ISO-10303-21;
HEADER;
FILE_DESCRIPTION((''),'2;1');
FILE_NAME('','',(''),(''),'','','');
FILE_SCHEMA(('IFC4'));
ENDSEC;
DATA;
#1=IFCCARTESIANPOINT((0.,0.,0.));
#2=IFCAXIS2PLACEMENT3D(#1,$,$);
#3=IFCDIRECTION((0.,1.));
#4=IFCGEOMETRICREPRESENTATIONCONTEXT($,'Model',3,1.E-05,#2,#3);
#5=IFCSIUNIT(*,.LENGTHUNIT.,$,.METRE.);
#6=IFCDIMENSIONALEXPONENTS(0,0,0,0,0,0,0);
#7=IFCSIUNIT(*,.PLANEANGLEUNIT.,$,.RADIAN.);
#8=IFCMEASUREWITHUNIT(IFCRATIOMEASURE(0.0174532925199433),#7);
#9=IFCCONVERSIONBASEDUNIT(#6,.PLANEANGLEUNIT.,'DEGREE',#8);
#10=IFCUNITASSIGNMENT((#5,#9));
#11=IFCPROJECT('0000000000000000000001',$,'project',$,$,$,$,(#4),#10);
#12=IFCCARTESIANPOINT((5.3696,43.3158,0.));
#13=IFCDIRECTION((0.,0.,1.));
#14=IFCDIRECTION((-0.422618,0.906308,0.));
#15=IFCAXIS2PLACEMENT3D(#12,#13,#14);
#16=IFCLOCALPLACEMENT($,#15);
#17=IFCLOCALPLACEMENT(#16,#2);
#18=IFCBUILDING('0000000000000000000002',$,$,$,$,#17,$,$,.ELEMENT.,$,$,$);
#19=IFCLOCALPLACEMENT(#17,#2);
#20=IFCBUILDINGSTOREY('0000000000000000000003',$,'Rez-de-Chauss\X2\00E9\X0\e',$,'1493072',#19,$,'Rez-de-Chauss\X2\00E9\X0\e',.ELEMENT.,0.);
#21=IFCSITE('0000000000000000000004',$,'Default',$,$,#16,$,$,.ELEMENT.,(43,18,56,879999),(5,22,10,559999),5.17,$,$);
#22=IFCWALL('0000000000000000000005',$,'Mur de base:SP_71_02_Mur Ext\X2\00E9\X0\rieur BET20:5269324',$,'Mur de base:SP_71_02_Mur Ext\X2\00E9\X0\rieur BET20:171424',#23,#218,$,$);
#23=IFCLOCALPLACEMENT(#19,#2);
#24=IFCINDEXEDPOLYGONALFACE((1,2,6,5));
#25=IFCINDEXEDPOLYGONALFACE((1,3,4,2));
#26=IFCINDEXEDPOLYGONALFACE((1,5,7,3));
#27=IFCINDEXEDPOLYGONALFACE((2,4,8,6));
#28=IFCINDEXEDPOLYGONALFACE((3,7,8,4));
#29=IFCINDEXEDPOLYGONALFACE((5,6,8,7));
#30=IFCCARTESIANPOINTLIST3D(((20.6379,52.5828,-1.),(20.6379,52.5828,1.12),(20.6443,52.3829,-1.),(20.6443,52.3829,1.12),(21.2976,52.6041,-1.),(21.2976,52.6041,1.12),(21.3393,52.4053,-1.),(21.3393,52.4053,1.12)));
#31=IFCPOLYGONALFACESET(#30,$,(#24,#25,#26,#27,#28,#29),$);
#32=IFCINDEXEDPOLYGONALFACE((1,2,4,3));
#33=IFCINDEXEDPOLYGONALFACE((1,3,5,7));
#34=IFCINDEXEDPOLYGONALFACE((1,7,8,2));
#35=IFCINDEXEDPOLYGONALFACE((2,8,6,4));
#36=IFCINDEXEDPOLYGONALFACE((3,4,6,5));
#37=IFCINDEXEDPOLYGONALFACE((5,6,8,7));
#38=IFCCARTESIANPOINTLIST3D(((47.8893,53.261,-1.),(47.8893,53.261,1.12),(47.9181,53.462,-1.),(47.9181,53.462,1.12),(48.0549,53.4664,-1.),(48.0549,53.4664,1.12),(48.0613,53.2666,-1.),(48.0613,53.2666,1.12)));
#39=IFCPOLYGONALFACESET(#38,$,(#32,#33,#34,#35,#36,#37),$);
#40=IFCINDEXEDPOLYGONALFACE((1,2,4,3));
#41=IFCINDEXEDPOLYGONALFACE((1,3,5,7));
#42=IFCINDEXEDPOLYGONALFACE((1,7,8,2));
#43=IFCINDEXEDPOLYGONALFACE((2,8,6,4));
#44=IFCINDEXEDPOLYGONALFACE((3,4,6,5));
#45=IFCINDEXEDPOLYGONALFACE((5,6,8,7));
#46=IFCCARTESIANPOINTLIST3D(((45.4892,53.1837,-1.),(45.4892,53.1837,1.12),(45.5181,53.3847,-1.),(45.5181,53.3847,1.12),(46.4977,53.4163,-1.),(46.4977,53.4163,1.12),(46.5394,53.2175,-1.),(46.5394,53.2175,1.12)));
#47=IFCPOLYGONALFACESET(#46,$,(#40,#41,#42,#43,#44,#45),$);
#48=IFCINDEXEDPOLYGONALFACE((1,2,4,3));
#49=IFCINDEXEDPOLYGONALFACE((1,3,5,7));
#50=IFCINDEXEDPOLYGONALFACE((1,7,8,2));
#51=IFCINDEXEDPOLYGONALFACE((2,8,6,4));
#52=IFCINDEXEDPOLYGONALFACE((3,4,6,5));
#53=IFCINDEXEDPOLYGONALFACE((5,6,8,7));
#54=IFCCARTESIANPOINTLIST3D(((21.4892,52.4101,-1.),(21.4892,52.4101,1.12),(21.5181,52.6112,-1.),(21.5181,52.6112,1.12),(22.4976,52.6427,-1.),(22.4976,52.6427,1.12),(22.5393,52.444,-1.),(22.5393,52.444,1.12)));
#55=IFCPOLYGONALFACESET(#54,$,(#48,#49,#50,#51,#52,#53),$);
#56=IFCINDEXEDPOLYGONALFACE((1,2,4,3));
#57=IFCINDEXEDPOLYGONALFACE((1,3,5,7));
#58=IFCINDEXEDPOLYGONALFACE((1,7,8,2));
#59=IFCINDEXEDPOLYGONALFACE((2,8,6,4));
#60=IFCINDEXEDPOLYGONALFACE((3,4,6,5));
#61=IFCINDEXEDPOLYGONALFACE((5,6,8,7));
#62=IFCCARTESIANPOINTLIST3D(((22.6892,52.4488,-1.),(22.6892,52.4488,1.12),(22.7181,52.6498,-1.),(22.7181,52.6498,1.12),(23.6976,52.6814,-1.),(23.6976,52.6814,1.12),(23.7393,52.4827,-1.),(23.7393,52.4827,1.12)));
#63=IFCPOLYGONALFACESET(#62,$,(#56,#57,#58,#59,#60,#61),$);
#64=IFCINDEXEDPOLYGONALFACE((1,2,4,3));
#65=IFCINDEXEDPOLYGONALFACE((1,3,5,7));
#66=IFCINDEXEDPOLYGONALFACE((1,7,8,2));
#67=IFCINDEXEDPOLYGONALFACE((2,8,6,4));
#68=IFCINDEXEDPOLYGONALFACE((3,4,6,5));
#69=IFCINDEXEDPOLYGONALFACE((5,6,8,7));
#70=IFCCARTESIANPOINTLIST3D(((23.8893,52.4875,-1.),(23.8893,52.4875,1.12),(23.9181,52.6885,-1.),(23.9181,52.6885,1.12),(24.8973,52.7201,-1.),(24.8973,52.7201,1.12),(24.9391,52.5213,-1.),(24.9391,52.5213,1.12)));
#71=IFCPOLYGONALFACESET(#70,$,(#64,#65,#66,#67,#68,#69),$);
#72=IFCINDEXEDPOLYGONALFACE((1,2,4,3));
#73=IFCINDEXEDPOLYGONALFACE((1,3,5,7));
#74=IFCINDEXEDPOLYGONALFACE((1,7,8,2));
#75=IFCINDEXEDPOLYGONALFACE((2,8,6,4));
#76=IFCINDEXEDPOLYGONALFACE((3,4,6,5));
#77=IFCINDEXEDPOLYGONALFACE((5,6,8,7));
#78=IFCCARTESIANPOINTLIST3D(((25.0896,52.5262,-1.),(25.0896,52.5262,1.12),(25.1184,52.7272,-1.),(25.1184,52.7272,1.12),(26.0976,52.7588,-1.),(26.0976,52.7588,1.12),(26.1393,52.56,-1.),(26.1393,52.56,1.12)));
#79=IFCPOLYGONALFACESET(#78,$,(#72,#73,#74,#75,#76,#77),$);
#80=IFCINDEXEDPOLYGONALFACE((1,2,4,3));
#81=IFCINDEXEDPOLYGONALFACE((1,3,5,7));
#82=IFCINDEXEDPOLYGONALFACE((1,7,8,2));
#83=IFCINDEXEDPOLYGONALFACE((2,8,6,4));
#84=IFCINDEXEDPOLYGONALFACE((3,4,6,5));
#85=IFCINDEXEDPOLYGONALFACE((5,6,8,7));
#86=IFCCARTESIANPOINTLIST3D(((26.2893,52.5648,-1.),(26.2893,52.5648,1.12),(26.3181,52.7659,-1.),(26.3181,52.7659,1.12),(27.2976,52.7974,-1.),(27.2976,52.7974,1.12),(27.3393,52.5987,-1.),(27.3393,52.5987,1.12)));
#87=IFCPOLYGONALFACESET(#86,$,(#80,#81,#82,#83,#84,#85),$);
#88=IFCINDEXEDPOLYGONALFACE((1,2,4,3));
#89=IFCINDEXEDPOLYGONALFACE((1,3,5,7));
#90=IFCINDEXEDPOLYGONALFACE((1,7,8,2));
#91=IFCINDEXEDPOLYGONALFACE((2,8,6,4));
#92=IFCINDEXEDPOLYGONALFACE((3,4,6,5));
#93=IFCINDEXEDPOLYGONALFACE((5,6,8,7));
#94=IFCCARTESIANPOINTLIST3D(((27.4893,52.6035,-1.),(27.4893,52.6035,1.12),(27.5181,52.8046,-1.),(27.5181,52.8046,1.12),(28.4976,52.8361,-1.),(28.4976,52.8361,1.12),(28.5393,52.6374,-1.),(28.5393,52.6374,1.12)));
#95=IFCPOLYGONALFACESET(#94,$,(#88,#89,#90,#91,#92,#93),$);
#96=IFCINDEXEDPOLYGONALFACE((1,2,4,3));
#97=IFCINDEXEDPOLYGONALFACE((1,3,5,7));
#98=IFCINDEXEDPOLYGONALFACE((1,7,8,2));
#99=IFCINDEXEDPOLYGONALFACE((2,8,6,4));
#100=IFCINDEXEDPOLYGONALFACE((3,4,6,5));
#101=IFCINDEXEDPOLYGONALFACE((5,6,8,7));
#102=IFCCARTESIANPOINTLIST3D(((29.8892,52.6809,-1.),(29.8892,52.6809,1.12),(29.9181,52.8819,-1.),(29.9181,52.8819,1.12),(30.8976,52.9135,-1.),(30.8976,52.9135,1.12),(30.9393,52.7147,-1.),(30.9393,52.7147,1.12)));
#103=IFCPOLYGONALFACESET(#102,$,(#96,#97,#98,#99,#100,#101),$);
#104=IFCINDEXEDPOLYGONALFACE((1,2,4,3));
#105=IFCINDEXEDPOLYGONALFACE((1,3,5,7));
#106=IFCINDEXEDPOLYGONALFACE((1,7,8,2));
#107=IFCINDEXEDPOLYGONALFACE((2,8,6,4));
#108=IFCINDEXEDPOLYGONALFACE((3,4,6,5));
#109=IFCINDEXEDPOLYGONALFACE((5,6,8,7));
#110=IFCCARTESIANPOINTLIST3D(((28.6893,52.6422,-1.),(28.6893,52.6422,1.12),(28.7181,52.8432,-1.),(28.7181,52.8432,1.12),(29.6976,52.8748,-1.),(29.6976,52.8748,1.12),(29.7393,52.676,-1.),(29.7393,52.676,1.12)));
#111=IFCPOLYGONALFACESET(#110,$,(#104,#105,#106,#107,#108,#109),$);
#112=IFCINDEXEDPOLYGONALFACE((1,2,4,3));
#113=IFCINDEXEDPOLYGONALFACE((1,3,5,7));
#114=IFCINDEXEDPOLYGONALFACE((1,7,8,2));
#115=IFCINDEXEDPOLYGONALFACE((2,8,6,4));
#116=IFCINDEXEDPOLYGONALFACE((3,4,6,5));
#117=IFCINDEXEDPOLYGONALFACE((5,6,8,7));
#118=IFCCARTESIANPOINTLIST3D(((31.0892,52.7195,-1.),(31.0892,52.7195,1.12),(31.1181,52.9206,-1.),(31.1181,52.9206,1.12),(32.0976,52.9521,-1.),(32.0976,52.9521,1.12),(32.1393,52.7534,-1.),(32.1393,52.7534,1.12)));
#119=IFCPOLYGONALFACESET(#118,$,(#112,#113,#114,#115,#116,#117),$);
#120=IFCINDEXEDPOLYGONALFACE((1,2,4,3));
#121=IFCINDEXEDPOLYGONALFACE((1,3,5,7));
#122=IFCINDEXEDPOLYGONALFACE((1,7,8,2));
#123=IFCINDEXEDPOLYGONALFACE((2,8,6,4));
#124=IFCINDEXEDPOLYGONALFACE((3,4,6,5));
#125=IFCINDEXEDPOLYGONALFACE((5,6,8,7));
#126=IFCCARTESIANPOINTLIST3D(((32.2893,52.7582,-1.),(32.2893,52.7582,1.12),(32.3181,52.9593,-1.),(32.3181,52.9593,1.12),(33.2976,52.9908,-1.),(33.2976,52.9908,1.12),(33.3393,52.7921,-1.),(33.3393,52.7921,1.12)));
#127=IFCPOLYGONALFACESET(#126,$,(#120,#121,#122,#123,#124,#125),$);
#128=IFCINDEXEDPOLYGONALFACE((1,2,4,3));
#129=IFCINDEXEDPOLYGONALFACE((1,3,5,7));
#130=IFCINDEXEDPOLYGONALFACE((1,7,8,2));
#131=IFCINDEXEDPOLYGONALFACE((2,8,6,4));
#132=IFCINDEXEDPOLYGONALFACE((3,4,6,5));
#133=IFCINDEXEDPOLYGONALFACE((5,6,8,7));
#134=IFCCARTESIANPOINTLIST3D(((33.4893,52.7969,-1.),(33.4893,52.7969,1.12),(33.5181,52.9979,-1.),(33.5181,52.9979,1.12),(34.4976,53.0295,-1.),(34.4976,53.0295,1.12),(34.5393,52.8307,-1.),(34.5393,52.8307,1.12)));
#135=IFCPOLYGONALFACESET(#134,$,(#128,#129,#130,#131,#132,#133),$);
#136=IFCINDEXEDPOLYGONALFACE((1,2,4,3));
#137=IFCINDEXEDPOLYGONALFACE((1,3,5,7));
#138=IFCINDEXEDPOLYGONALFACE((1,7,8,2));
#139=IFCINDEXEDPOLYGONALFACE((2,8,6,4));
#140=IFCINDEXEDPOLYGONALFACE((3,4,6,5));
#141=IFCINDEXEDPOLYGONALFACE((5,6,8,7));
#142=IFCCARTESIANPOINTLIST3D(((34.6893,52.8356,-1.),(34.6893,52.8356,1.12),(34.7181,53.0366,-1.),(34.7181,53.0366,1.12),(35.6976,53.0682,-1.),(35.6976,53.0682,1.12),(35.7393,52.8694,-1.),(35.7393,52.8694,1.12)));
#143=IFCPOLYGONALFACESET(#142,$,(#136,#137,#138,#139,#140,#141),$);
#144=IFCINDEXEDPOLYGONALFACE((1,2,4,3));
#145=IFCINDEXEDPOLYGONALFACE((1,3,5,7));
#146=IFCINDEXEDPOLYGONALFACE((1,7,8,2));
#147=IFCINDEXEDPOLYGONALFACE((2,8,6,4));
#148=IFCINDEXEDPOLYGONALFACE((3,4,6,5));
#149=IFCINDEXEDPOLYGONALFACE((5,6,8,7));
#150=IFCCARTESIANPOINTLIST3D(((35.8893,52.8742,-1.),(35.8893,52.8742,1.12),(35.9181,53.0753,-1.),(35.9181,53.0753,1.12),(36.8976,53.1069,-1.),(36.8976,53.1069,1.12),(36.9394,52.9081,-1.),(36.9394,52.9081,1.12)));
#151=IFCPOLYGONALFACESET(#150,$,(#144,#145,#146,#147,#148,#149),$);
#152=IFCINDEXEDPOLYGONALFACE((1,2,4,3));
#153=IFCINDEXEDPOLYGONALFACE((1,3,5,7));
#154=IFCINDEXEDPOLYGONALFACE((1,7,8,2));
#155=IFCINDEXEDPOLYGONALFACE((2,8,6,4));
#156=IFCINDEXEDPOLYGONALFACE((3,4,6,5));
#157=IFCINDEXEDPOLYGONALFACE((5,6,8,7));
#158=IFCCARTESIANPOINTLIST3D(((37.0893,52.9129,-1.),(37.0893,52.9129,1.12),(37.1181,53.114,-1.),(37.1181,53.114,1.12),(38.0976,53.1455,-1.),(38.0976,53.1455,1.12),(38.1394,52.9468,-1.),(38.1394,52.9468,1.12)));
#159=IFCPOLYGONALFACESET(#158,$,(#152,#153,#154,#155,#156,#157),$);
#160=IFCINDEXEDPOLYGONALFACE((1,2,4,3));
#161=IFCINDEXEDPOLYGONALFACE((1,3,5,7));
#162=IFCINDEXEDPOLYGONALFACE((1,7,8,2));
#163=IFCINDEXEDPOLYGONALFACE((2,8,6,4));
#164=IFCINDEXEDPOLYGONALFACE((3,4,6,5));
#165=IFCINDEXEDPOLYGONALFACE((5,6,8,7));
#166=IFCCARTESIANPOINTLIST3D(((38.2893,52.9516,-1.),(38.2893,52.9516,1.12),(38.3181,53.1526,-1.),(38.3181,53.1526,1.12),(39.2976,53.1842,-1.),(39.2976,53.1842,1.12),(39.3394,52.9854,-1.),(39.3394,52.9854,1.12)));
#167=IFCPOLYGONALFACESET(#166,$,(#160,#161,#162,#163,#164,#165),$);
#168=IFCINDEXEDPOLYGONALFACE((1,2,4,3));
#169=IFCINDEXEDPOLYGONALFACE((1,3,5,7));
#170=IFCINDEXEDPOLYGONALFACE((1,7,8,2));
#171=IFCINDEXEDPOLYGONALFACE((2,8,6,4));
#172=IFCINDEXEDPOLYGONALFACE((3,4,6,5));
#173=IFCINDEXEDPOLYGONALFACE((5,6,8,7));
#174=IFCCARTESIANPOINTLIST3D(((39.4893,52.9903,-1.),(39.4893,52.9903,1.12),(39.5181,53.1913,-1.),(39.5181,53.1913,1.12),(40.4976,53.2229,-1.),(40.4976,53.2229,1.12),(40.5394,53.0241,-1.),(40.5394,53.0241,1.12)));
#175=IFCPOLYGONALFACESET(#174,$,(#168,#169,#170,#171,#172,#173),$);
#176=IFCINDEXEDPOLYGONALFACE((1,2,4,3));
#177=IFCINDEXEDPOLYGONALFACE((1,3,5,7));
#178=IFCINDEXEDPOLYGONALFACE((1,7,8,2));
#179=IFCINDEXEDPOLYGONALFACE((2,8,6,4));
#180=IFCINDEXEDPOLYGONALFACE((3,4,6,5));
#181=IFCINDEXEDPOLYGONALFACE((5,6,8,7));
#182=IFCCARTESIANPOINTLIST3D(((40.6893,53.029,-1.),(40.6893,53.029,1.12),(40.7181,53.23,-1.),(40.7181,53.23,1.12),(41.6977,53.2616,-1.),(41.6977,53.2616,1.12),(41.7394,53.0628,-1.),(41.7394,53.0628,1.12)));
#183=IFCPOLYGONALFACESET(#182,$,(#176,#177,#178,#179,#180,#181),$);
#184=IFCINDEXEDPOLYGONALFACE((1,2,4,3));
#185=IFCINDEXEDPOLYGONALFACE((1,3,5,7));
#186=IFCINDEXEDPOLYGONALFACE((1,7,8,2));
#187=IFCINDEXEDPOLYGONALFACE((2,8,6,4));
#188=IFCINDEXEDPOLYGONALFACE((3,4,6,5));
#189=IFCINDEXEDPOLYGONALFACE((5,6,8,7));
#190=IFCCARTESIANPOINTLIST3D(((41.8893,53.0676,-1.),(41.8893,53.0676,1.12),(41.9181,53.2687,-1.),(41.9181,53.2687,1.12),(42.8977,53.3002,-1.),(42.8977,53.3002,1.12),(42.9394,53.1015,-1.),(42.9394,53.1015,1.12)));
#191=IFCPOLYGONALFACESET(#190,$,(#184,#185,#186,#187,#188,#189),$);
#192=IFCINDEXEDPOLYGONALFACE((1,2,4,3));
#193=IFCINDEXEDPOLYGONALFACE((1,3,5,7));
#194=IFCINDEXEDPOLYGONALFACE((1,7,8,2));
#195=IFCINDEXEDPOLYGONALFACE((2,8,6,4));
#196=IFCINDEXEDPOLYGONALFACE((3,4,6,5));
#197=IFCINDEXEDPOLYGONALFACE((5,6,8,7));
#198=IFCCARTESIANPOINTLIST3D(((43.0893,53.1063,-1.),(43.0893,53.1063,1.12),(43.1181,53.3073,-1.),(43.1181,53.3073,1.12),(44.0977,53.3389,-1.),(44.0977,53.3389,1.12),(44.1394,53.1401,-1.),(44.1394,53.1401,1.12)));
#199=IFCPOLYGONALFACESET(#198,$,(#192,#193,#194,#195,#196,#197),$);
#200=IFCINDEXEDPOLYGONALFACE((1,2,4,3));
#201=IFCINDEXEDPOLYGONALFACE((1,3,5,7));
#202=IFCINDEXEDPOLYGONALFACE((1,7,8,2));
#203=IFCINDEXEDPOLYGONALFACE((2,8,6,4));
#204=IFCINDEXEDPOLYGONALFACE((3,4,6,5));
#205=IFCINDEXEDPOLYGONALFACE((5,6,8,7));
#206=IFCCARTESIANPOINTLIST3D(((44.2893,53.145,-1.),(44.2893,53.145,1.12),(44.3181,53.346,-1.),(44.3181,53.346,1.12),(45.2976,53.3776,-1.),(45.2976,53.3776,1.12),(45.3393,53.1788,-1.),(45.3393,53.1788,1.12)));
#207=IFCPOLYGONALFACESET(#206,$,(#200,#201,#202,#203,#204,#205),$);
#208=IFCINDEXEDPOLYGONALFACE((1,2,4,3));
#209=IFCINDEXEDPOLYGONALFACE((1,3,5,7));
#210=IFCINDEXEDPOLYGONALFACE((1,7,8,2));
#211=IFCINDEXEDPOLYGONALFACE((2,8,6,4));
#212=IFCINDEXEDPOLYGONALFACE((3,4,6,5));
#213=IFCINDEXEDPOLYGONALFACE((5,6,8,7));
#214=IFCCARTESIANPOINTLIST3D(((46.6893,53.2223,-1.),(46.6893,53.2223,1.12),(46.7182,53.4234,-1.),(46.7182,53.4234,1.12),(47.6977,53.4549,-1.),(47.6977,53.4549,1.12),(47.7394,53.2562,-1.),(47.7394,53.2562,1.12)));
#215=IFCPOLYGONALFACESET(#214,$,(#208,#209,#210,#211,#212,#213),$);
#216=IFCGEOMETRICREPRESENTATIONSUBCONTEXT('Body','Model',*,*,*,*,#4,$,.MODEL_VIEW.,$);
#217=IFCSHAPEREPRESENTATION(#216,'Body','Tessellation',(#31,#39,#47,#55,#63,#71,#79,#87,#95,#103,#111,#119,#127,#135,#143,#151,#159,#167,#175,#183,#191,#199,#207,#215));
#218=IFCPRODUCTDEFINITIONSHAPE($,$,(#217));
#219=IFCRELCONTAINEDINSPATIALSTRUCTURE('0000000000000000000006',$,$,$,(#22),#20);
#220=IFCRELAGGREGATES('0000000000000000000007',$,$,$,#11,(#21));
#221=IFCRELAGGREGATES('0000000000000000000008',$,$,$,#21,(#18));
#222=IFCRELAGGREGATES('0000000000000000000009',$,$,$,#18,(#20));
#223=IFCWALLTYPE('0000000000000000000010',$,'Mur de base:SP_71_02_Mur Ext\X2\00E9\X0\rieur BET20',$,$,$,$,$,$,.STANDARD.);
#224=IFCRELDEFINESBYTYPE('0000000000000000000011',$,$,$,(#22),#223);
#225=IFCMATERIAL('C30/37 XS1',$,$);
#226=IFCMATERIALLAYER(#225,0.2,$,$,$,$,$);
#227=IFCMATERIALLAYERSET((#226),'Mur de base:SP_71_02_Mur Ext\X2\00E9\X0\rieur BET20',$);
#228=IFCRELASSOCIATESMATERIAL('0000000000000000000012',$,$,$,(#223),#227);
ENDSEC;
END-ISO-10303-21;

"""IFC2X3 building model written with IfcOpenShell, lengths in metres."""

from ifc_helpers import new_model, entity, si_unit, converted_unit, direction, frame, origin, place, context, subcontext, project, spatial, polyline, outline, extrude, material, layer, layer_set, type_object, element, save


model = new_model("IFC2X3")

# Units and contexts
model_context = context("Model", 3, precision=1e-05, world=origin(), true_north=direction((0.0, 1.0)))
body_context = subcontext(model_context, "Body", "Model", "MODEL_VIEW")
ifc_project = project(units=[si_unit("LENGTHUNIT", "METRE"), converted_unit("PLANEANGLEUNIT", "DEGREE", entity("IfcRatioMeasure", 0.0174532925199433), si_unit("PLANEANGLEUNIT", "RADIAN"), dimensions=[0, 0, 0, 0, 0, 0, 0])], contexts=[model_context])

# Site, building, storey
site_placement = place(None, frame((5.3696, 43.3158, 0.0), z_axis=(0.0, 0.0, 1.0), x_axis=(-0.422618, 0.906308, 0.0)))
site = spatial("IfcSite", under=ifc_project, at=site_placement, Name="Default", CompositionType="ELEMENT", RefLatitude=(43, 18, 56, 879999), RefLongitude=(5, 22, 10, 559999), RefElevation=5.17)
building_placement = place(site_placement, origin())
building = spatial("IfcBuilding", under=site, at=building_placement, CompositionType="ELEMENT")
storey_placement = place(building_placement, origin())
storey = spatial("IfcBuildingStorey", under=building, at=storey_placement, Name="Rez-de-Chaussée", ObjectType="1493072", LongName="Rez-de-Chaussée", CompositionType="ELEMENT", Elevation=0.0)

# Wall
ifc_material_1 = material(Name="C30/37 XS1")
ifc_layer_1 = layer(ifc_material_1, 0.2)
ifc_layer_set_1 = layer_set([ifc_layer_1], Name="Mur de base:SP_71_02_Mur Extérieur BET20")
wall_type_1 = type_object("IfcWallType", Name="Mur de base:SP_71_02_Mur Extérieur BET20", PredefinedType="STANDARD", material=ifc_layer_set_1)
wall_1_placement = place(storey_placement, frame((20.6411, 52.4829, -1.0), z_axis=(0.0, 0.0, 1.0), x_axis=(0.999481, 0.032213, 0.0)))
element("IfcWall", 1, at=wall_1_placement, inside=storey, type_object=wall_type_1, Name="Mur de base:SP_71_02_Mur Extérieur BET20:5269324", ObjectType="Mur de base:SP_71_02_Mur Extérieur BET20:171424", context=body_context, shape_type="SweptSolid", body=[
    extrude(outline(polyline([(-0.3389, -0.1), (0.3565, -0.1), (0.3212, 0.1), (-0.3389, 0.1), (-0.3389, -0.1)])), frame((0.3389, 0.0, 0.0)), (0.0, 0.0, 1.0), 2.12),
    extrude(outline(polyline([(-0.0772, -0.1), (0.0596, -0.1), (0.0949, 0.1), (-0.0772, 0.1), (-0.0772, -0.1)])), frame((27.354, 0.0, 0.0), z_axis=(0.0, 0.0, 1.0), x_axis=(-1.0, 0.0, 0.0)), (0.0, 0.0, 1.0), 2.12),
    extrude(outline(polyline([(-0.4901, -0.1), (0.4901, -0.1), (0.5254, 0.1), (-0.5254, 0.1), (-0.4901, -0.1)])), frame((25.3832, 0.0, 0.0), z_axis=(0.0, 0.0, 1.0), x_axis=(-1.0, 0.0, 0.0)), (0.0, 0.0, 1.0), 2.12),
    extrude(outline(polyline([(-0.5253, -0.1), (0.5253, -0.1), (0.49, 0.1), (-0.49, 0.1), (-0.5253, -0.1)])), frame((1.3707, 0.0, 0.0)), (0.0, 0.0, 1.0), 2.12),
    extrude(outline(polyline([(-0.5253, -0.1), (0.5253, -0.1), (0.49, 0.1), (-0.49, 0.1), (-0.5253, -0.1)])), frame((2.5713, 0.0, 0.0)), (0.0, 0.0, 1.0), 2.12),
    extrude(outline(polyline([(-0.5252, -0.1), (0.5252, -0.1), (0.4899, 0.1), (-0.4899, 0.1), (-0.5252, -0.1)])), frame((3.7718, 0.0, 0.0)), (0.0, 0.0, 1.0), 2.12),
    extrude(outline(polyline([(-0.4899, -0.1), (0.4899, -0.1), (0.5252, 0.1), (-0.5252, 0.1), (-0.4899, -0.1)])), frame((4.9727, 0.0, 0.0), z_axis=(0.0, 0.0, 1.0), x_axis=(-1.0, 0.0, 0.0)), (0.0, 0.0, 1.0), 2.12),
    extrude(outline(polyline([(-0.5253, -0.1), (0.5253, -0.1), (0.49, 0.1), (-0.49, 0.1), (-0.5253, -0.1)])), frame((6.1732, 0.0, 0.0)), (0.0, 0.0, 1.0), 2.12),
    extrude(outline(polyline([(-0.5253, -0.1), (0.5253, -0.1), (0.49, 0.1), (-0.49, 0.1), (-0.5253, -0.1)])), frame((7.3738, 0.0, 0.0)), (0.0, 0.0, 1.0), 2.12),
    extrude(outline(polyline([(-0.5253, -0.1), (0.5253, -0.1), (0.49, 0.1), (-0.49, 0.1), (-0.5253, -0.1)])), frame((9.775, 0.0, 0.0)), (0.0, 0.0, 1.0), 2.12),
    extrude(outline(polyline([(-0.49, -0.1), (0.49, -0.1), (0.5253, 0.1), (-0.5253, 0.1), (-0.49, -0.1)])), frame((8.5744, 0.0, 0.0), z_axis=(0.0, 0.0, 1.0), x_axis=(-1.0, 0.0, 0.0)), (0.0, 0.0, 1.0), 2.12),
    extrude(outline(polyline([(-0.5253, -0.1), (0.5253, -0.1), (0.49, 0.1), (-0.49, 0.1), (-0.5253, -0.1)])), frame((10.9757, 0.0, 0.0)), (0.0, 0.0, 1.0), 2.12),
    extrude(outline(polyline([(-0.49, -0.1), (0.49, -0.1), (0.5253, 0.1), (-0.5253, 0.1), (-0.49, -0.1)])), frame((12.1763, 0.0, 0.0), z_axis=(0.0, 0.0, 1.0), x_axis=(-1.0, 0.0, 0.0)), (0.0, 0.0, 1.0), 2.12),
    extrude(outline(polyline([(-0.5253, -0.1), (0.5253, -0.1), (0.49, 0.1), (-0.49, 0.1), (-0.5253, -0.1)])), frame((13.3769, 0.0, 0.0)), (0.0, 0.0, 1.0), 2.12),
    extrude(outline(polyline([(-0.5253, -0.1), (0.5253, -0.1), (0.49, 0.1), (-0.49, 0.1), (-0.5253, -0.1)])), frame((14.5775, 0.0, 0.0)), (0.0, 0.0, 1.0), 2.12),
    extrude(outline(polyline([(-0.5253, -0.1), (0.5253, -0.1), (0.49, 0.1), (-0.49, 0.1), (-0.5253, -0.1)])), frame((15.7782, 0.0, 0.0)), (0.0, 0.0, 1.0), 2.12),
    extrude(outline(polyline([(-0.49, -0.1), (0.49, -0.1), (0.5253, 0.1), (-0.5253, 0.1), (-0.49, -0.1)])), frame((16.9788, 0.0, 0.0), z_axis=(0.0, 0.0, 1.0), x_axis=(-1.0, 0.0, 0.0)), (0.0, 0.0, 1.0), 2.12),
    extrude(outline(polyline([(-0.5253, -0.1), (0.5253, -0.1), (0.49, 0.1), (-0.49, 0.1), (-0.5253, -0.1)])), frame((18.1794, 0.0, 0.0)), (0.0, 0.0, 1.0), 2.12),
    extrude(outline(polyline([(-0.5253, -0.1), (0.5253, -0.1), (0.49, 0.1), (-0.49, 0.1), (-0.5253, -0.1)])), frame((19.3801, 0.0, 0.0)), (0.0, 0.0, 1.0), 2.12),
    extrude(outline(polyline([(-0.5253, -0.1), (0.5253, -0.1), (0.49, 0.1), (-0.49, 0.1), (-0.5253, -0.1)])), frame((20.5807, 0.0, 0.0)), (0.0, 0.0, 1.0), 2.12),
    extrude(outline(polyline([(-0.49, -0.1), (0.49, -0.1), (0.5253, 0.1), (-0.5253, 0.1), (-0.49, -0.1)])), frame((21.7813, 0.0, 0.0), z_axis=(0.0, 0.0, 1.0), x_axis=(-1.0, 0.0, 0.0)), (0.0, 0.0, 1.0), 2.12),
    extrude(outline(polyline([(-0.5253, -0.1), (0.5253, -0.1), (0.49, 0.1), (-0.49, 0.1), (-0.5253, -0.1)])), frame((22.9819, 0.0, 0.0)), (0.0, 0.0, 1.0), 2.12),
    extrude(outline(polyline([(-0.5253, -0.1), (0.5253, -0.1), (0.49, 0.1), (-0.49, 0.1), (-0.5253, -0.1)])), frame((24.1825, 0.0, 0.0)), (0.0, 0.0, 1.0), 2.12),
    extrude(outline(polyline([(-0.49, -0.1), (0.49, -0.1), (0.5253, 0.1), (-0.5253, 0.1), (-0.49, -0.1)])), frame((26.5838, 0.0, 0.0), z_axis=(0.0, 0.0, 1.0), x_axis=(-1.0, 0.0, 0.0)), (0.0, 0.0, 1.0), 2.12),
])

save(model, "model.ifc")
